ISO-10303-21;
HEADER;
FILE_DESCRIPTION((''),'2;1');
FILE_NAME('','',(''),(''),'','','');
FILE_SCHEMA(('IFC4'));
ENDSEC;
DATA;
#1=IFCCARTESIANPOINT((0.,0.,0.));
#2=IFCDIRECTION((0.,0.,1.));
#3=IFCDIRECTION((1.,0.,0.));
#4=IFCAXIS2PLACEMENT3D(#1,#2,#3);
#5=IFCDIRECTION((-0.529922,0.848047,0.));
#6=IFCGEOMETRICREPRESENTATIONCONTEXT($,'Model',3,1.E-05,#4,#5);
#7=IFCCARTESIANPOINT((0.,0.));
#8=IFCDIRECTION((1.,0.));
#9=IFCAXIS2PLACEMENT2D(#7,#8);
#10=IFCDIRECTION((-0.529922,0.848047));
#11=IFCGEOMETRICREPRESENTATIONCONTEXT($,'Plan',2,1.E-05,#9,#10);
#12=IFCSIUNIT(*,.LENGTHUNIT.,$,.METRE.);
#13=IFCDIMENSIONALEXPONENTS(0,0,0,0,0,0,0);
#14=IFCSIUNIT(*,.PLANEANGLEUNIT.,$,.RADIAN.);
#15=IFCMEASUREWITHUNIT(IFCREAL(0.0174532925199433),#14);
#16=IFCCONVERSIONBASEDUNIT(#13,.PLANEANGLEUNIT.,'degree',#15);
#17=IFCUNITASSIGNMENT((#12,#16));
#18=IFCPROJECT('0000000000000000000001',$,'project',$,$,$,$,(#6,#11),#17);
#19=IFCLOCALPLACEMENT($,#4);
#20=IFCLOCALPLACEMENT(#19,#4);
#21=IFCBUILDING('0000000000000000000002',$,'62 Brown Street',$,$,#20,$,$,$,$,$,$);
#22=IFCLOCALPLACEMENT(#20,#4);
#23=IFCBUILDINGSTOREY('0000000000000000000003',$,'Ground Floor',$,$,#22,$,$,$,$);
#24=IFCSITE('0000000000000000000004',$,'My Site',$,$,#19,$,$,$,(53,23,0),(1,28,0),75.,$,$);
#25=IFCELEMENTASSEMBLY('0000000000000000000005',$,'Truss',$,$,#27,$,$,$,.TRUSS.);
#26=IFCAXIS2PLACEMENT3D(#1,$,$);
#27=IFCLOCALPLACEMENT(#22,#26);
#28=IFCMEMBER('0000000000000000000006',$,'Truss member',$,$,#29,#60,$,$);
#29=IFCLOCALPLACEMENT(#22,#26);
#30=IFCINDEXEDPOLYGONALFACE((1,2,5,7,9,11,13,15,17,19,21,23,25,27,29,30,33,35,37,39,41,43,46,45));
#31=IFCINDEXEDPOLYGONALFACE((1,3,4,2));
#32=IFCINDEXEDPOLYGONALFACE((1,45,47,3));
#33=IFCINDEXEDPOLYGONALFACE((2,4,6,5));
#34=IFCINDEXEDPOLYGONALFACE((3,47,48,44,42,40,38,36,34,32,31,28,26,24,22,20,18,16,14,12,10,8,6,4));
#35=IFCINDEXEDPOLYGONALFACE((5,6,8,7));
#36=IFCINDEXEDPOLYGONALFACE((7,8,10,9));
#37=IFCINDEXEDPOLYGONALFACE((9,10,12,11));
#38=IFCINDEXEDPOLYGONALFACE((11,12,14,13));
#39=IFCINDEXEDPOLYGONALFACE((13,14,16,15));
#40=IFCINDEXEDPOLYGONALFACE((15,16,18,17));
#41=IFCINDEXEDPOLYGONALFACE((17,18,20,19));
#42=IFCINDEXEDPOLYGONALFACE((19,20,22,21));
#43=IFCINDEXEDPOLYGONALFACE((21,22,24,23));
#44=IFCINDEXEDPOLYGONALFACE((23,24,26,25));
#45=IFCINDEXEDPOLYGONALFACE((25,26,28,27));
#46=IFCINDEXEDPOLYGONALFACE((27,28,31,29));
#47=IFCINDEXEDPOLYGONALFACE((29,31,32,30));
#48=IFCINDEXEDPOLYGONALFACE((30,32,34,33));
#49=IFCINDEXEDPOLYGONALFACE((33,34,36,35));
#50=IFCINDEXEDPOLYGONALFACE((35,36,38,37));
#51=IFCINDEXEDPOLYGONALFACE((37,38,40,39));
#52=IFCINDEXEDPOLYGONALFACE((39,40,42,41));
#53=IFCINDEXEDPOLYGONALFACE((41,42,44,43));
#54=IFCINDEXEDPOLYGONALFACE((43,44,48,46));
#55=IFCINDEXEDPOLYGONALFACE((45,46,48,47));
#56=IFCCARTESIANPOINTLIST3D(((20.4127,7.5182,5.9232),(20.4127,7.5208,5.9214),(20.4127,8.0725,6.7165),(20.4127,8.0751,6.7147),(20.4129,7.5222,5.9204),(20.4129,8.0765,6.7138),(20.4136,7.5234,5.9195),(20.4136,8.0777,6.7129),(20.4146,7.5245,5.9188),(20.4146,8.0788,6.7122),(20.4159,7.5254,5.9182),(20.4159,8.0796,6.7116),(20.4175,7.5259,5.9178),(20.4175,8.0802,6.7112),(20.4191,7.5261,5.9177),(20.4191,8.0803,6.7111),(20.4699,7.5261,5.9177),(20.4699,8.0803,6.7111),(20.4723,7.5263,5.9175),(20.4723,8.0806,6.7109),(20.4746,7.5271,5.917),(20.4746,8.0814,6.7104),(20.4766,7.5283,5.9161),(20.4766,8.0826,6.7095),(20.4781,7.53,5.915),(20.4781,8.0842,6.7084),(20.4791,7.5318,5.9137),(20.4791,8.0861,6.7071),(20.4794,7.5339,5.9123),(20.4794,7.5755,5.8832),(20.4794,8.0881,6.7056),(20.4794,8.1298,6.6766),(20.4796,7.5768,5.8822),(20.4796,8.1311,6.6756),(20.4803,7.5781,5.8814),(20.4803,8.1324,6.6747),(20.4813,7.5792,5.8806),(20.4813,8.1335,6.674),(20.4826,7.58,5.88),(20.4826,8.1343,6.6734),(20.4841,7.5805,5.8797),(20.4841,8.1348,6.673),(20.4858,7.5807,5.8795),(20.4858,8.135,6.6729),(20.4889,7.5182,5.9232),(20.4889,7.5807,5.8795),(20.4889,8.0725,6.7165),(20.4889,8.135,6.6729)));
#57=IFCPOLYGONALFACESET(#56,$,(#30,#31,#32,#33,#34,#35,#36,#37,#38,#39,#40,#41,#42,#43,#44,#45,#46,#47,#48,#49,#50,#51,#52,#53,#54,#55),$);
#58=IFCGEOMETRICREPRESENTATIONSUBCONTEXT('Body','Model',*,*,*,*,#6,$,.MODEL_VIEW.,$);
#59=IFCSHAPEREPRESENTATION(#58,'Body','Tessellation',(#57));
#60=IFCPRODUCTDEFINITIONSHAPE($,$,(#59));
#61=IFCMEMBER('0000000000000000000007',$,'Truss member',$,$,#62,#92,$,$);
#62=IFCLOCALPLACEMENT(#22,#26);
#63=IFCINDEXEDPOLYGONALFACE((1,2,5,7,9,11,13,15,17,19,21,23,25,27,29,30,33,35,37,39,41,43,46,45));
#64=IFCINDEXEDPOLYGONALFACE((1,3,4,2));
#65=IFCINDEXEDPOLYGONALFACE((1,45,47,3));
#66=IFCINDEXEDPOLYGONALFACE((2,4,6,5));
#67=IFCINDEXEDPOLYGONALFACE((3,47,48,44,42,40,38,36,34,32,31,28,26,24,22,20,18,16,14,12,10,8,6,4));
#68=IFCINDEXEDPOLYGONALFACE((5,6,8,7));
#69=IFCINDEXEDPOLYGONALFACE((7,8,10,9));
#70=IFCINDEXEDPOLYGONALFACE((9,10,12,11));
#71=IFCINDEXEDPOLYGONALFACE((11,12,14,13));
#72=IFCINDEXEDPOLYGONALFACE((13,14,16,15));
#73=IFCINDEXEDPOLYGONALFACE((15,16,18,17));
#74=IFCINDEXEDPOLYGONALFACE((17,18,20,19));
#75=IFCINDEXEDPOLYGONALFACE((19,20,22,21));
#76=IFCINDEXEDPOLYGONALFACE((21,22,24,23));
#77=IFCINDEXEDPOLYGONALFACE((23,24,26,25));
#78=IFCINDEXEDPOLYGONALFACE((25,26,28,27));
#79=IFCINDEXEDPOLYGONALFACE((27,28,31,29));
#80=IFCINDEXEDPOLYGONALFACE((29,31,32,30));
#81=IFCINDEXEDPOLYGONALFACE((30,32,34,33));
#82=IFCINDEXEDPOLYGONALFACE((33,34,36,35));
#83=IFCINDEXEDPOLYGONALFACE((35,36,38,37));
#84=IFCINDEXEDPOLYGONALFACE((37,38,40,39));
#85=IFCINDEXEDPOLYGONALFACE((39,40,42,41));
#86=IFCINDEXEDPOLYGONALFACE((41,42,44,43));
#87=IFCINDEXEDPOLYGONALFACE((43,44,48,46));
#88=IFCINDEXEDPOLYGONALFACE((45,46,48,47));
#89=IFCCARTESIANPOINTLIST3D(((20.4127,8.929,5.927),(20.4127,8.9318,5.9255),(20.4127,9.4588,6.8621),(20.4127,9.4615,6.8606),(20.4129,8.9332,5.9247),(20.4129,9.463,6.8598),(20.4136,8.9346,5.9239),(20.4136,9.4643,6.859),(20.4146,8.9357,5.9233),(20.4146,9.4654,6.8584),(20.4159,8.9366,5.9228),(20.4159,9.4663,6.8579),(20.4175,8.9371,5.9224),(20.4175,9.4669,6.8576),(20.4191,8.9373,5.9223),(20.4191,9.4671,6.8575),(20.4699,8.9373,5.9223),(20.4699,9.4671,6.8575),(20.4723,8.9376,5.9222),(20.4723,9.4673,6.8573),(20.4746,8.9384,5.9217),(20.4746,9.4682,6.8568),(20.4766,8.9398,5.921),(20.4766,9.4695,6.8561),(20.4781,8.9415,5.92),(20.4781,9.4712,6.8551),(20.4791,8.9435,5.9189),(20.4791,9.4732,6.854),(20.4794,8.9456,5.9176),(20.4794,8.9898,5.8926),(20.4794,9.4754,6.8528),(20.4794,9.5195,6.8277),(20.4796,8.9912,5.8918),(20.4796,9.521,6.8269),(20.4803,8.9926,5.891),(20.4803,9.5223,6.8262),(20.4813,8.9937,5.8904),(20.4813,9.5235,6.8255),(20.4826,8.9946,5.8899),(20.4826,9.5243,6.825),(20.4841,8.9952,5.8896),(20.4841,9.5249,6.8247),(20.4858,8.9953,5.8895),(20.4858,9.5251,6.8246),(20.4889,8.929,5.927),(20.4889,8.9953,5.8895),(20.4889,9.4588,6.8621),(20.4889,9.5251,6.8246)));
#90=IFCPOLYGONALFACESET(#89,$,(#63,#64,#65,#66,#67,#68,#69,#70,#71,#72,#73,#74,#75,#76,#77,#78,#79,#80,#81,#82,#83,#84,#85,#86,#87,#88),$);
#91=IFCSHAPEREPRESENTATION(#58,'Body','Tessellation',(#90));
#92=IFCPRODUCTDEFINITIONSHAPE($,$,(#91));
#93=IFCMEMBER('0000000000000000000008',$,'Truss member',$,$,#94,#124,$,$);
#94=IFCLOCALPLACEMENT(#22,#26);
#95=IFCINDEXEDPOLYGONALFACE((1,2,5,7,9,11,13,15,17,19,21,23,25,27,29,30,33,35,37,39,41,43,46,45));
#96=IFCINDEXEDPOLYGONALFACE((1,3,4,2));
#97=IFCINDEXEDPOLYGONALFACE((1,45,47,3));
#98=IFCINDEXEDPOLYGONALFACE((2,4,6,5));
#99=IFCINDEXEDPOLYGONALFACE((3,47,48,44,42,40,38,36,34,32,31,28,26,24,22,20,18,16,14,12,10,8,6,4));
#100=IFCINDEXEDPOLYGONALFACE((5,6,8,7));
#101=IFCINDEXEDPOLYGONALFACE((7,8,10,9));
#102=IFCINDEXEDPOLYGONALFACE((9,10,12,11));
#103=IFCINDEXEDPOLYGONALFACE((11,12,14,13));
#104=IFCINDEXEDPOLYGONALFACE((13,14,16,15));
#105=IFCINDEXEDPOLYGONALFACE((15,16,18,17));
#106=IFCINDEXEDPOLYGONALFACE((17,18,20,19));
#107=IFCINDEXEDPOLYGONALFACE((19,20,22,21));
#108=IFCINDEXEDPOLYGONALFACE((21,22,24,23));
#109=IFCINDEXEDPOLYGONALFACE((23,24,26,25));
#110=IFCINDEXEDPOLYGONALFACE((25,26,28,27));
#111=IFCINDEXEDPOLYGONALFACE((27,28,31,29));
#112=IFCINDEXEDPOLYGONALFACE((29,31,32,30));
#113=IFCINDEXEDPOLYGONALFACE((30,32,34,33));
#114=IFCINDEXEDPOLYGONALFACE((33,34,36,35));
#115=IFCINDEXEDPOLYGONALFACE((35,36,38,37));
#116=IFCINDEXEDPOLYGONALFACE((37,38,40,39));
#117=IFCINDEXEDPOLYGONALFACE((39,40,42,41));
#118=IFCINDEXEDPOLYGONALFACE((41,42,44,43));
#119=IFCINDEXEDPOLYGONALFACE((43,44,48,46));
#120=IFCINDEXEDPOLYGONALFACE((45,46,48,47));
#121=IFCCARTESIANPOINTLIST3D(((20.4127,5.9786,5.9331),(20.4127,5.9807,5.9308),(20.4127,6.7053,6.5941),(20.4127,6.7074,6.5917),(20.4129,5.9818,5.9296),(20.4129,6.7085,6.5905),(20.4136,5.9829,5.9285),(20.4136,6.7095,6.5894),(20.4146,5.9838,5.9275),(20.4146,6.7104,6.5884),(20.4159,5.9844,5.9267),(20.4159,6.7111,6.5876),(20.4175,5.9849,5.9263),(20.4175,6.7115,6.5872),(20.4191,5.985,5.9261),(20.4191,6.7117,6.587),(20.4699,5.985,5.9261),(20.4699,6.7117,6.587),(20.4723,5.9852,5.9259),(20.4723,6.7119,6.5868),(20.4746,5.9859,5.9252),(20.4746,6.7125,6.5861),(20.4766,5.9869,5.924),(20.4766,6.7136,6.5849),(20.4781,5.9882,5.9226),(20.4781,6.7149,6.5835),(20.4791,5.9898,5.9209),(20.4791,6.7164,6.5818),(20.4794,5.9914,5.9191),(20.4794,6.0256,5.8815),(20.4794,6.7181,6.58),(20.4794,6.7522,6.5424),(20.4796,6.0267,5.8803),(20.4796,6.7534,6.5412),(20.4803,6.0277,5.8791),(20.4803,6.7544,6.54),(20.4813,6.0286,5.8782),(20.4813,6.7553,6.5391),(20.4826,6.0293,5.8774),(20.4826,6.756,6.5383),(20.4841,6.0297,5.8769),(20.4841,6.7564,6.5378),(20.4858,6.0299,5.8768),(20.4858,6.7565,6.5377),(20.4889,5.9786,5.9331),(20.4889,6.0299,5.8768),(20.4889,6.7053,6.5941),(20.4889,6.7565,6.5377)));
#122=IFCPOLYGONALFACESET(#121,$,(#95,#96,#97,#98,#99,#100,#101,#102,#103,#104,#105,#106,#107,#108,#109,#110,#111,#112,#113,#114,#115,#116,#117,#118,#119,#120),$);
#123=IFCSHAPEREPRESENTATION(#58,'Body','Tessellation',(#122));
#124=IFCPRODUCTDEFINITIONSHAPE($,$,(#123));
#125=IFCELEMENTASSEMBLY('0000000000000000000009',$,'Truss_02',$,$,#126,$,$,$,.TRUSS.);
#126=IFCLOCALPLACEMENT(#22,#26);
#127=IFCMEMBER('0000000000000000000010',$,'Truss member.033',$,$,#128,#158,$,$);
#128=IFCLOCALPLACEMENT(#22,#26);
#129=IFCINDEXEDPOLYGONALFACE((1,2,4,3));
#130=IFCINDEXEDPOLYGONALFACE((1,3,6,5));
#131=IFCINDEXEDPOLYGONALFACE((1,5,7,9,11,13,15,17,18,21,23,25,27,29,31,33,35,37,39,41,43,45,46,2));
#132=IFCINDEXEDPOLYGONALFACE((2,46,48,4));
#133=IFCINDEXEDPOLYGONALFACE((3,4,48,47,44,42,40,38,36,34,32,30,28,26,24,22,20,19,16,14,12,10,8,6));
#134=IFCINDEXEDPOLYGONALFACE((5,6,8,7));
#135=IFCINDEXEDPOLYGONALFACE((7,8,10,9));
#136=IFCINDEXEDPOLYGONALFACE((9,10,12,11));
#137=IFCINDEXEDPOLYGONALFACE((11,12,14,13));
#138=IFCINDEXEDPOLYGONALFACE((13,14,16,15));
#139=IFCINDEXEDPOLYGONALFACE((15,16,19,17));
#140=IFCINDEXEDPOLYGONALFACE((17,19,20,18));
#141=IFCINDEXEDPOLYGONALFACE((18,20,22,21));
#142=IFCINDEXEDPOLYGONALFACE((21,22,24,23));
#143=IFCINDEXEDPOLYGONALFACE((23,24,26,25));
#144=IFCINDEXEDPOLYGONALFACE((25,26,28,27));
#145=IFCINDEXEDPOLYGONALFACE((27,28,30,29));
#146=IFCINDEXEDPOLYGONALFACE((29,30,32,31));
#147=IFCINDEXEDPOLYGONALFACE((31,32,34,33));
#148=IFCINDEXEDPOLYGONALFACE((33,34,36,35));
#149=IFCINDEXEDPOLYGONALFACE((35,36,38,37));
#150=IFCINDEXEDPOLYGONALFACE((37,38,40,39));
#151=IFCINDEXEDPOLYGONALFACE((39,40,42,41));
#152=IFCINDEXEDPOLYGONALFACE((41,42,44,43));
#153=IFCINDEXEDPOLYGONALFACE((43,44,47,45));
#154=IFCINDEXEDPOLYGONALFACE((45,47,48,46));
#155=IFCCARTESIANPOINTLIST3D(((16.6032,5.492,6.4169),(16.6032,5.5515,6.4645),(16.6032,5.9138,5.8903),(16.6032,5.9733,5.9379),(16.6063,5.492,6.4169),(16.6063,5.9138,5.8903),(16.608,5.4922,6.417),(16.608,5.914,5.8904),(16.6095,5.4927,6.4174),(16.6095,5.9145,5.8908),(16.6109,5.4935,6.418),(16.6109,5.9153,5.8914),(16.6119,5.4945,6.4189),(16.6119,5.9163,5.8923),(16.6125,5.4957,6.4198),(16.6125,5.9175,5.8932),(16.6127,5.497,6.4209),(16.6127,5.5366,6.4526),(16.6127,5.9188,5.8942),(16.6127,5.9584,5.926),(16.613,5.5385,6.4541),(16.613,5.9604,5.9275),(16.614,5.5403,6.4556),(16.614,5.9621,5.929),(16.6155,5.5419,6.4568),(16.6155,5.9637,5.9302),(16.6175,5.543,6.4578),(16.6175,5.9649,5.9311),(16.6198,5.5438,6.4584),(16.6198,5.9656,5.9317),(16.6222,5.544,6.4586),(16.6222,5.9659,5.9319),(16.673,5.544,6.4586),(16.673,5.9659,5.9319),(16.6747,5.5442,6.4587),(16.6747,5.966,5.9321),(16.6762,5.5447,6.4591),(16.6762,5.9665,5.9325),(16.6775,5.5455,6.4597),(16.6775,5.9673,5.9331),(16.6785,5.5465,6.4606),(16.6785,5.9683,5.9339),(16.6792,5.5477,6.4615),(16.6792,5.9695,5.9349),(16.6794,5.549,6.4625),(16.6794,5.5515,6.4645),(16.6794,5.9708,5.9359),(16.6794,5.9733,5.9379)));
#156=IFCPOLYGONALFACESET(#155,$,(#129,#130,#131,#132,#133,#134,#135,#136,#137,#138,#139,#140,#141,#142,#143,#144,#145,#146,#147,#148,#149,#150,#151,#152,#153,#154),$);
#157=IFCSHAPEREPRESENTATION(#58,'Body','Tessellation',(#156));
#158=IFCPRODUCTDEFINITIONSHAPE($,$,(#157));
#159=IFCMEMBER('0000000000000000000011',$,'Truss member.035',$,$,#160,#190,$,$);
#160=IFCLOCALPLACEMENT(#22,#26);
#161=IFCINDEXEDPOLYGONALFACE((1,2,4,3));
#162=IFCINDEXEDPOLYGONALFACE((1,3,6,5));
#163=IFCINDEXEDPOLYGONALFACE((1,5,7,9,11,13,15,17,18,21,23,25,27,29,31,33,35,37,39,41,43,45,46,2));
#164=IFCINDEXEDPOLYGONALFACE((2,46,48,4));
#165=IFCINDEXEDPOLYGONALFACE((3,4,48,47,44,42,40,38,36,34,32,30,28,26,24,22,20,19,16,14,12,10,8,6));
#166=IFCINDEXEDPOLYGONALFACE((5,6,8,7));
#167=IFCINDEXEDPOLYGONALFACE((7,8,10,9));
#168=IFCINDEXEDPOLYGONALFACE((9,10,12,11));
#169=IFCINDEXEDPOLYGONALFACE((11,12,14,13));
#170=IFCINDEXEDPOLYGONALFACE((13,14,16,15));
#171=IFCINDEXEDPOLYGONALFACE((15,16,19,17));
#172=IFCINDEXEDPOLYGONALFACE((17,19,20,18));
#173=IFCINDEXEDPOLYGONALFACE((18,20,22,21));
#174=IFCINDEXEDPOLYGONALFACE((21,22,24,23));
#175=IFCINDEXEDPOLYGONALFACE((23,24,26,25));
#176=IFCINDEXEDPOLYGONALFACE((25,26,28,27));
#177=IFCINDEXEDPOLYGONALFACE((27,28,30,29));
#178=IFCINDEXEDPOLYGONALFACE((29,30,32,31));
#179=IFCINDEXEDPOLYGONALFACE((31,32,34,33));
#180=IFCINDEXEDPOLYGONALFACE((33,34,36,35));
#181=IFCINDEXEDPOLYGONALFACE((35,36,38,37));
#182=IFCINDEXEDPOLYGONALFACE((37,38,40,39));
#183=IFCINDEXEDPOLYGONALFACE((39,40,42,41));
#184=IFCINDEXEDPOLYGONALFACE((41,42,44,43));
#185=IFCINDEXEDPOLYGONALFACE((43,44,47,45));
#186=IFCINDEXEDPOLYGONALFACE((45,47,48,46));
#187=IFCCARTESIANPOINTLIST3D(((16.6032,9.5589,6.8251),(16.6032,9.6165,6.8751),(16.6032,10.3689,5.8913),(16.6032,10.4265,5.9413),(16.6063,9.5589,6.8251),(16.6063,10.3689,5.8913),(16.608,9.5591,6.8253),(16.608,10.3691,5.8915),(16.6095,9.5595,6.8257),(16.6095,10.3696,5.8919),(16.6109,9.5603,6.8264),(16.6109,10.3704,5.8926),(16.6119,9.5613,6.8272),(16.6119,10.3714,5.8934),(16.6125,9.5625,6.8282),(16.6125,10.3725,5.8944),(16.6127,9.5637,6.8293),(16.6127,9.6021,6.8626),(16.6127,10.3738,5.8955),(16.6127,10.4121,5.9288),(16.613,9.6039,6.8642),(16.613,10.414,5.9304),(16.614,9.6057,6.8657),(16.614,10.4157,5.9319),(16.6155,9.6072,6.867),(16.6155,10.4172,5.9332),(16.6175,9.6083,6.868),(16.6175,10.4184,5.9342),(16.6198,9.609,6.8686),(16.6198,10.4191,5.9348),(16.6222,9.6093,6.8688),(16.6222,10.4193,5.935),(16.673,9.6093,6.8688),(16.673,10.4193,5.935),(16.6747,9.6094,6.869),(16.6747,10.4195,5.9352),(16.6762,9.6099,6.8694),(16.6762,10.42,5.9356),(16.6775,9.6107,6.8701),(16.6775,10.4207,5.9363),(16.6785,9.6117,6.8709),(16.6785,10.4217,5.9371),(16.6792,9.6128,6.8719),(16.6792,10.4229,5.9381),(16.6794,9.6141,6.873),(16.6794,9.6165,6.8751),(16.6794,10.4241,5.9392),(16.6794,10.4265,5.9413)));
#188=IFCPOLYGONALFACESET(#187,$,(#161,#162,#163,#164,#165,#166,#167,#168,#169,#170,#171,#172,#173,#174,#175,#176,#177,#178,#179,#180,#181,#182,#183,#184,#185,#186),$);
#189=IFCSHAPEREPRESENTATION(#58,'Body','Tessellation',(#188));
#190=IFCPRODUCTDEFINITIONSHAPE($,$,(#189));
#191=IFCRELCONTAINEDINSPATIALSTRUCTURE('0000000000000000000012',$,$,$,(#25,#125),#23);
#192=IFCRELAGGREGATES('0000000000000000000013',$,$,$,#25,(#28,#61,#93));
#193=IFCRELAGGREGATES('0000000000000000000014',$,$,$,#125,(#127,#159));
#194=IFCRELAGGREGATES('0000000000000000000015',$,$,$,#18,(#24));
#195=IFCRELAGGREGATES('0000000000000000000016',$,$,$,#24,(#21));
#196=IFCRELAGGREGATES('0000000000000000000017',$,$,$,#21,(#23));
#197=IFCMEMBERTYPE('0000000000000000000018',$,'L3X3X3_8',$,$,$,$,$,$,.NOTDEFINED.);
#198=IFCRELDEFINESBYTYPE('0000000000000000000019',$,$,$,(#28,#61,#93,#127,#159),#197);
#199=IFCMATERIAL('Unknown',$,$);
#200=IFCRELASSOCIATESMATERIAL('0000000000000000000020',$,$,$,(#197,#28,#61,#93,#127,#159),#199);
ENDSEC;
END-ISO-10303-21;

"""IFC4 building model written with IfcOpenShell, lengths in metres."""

from ifc_helpers import new_model, entity, si_unit, converted_unit, direction, frame, origin_with_axes, origin_2d_with_axis, place, context, subcontext, project, spatial, l_section, extrude, material, material_profile, profile_set, profile_usage, type_object, element, aggregate, save


model = new_model("IFC4")

# Units and contexts
model_context = context("Model", 3, precision=1e-05, world=origin_with_axes(), true_north=direction((-0.529922, 0.848047, 0.0)))
plan_context = context("Plan", 2, precision=1e-05, world=origin_2d_with_axis(), true_north=direction((-0.529922, 0.848047)))
body_context_1 = subcontext(model_context, "Body", "Model", "MODEL_VIEW")
ifc_project = project(units=[si_unit("LENGTHUNIT", "METRE"), converted_unit("PLANEANGLEUNIT", "degree", entity("IfcReal", 0.0174532925199433), si_unit("PLANEANGLEUNIT", "RADIAN"), dimensions=[0, 0, 0, 0, 0, 0, 0])], contexts=[model_context, plan_context])

# Site, building, storey
site_placement = place(None, origin_with_axes())
site = spatial("IfcSite", under=ifc_project, at=site_placement, Name="My Site", RefLatitude=(53, 23, 0), RefLongitude=(1, 28, 0), RefElevation=75.0)
building_placement = place(site_placement, origin_with_axes())
building = spatial("IfcBuilding", under=site, at=building_placement, Name="62 Brown Street")
storey_placement = place(building_placement, origin_with_axes())
storey = spatial("IfcBuildingStorey", under=building, at=storey_placement, Name="Ground Floor")

# Element assemblies, members
assembly_1_placement = place(storey_placement, frame((20.5032, 10.4288, 6.9738), z_axis=(0.0, 0.0, 1.0), x_axis=(1.0, 0.0, 0.0)))
assembly_1 = element("IfcElementAssembly", 1, at=assembly_1_placement, inside=storey, Name="Truss", PredefinedType="TRUSS")
ifc_material_1 = material(Name="Unknown")
ifc_material_profile_1 = material_profile(ifc_material_1, l_section(Depth=0.0762, Width=0.0762, Thickness=0.0095, FilletRadius=0.0095, EdgeRadius=0.0064))
ifc_profile_set_1 = profile_set([ifc_material_profile_1])
ifc_profile_usage_1 = profile_usage(ifc_profile_set_1, cardinal=5)
member_type_1 = type_object("IfcMemberType", Name="L3X3X3_8", PredefinedType="NOTDEFINED", material=ifc_profile_set_1)
member_1_placement = place(assembly_1_placement, frame((-0.0524, -2.325, -0.279), z_axis=(0.000001, -0.572709, -0.819759), x_axis=(-1.0, -0.000001, 0.0)))
member_1 = element("IfcMember", 2, at=member_1_placement, type_object=member_type_1, material=ifc_profile_usage_1, Name="Truss member", context=body_context_1, shape_type="SweptSolid", body=[
    extrude(l_section(Depth=0.0762, Width=0.0762, Thickness=0.0095, FilletRadius=0.0095, EdgeRadius=0.0064), origin_with_axes(), (0.0, 0.0, 1.0), 0.9678),
])
ifc_profile_usage_2 = profile_usage(ifc_profile_set_1, cardinal=5)
member_2_placement = place(assembly_1_placement, frame((-0.0524, -0.9369, -0.1304), z_axis=(0.0, -0.492899, -0.870086), x_axis=(-1.0, 0.0, 0.0)))
member_2 = element("IfcMember", 3, at=member_2_placement, type_object=member_type_1, material=ifc_profile_usage_2, Name="Truss member", context=body_context_1, shape_type="SweptSolid", body=[
    extrude(l_section(Depth=0.0762, Width=0.0762, Thickness=0.0095, FilletRadius=0.0095, EdgeRadius=0.0064), origin_with_axes(), (0.0, 0.0, 1.0), 1.0747),
])
ifc_profile_usage_3 = profile_usage(ifc_profile_set_1, cardinal=5)
member_3_placement = place(assembly_1_placement, frame((-0.0524, -3.6979, -0.4079), z_axis=(0.000001, -0.739785, -0.672843), x_axis=(-1.0, -0.000001, 0.0)))
member_3 = element("IfcMember", 4, at=member_3_placement, type_object=member_type_1, material=ifc_profile_usage_3, Name="Truss member", context=body_context_1, shape_type="SweptSolid", body=[
    extrude(l_section(Depth=0.0762, Width=0.0762, Thickness=0.0095, FilletRadius=0.0095, EdgeRadius=0.0064), origin_with_axes(), (0.0, 0.0, 1.0), 0.9823),
])
aggregate(assembly_1, [member_1, member_2, member_3])
assembly_2_placement = place(storey_placement, frame((16.6032, 10.4288, 6.9738), z_axis=(0.0, 0.0, 1.0), x_axis=(1.0, 0.0, 0.0)))
assembly_2 = element("IfcElementAssembly", 5, at=assembly_2_placement, inside=storey, Name="Truss_02", PredefinedType="TRUSS")
ifc_profile_usage_4 = profile_usage(ifc_profile_set_1, cardinal=5)
member_4_placement = place(assembly_2_placement, frame((0.0381, -4.907, -0.5331), z_axis=(-0.000001, 0.625169, -0.780489), x_axis=(1.0, 0.000001, 0.0)))
member_4 = element("IfcMember", 6, at=member_4_placement, type_object=member_type_1, material=ifc_profile_usage_4, Name="Truss member.033", context=body_context_1, shape_type="SweptSolid", body=[
    extrude(l_section(Depth=0.0762, Width=0.0762, Thickness=0.0095, FilletRadius=0.0095, EdgeRadius=0.0064), origin_with_axes(), (0.0, 0.0, 1.0), 0.6747),
])
ifc_profile_usage_5 = profile_usage(ifc_profile_set_1, cardinal=5)
member_5_placement = place(assembly_2_placement, frame((0.0381, -0.8411, -0.1236), z_axis=(-0.000001, 0.655276, -0.755389), x_axis=(1.0, 0.000001, 0.0)))
member_5 = element("IfcMember", 7, at=member_5_placement, type_object=member_type_1, material=ifc_profile_usage_5, Name="Truss member.035", context=body_context_1, shape_type="SweptSolid", body=[
    extrude(l_section(Depth=0.0762, Width=0.0762, Thickness=0.0095, FilletRadius=0.0095, EdgeRadius=0.0064), origin_with_axes(), (0.0, 0.0, 1.0), 1.2362),
])

aggregate(assembly_2, [member_4, member_5])

save(model, "model.ifc")
